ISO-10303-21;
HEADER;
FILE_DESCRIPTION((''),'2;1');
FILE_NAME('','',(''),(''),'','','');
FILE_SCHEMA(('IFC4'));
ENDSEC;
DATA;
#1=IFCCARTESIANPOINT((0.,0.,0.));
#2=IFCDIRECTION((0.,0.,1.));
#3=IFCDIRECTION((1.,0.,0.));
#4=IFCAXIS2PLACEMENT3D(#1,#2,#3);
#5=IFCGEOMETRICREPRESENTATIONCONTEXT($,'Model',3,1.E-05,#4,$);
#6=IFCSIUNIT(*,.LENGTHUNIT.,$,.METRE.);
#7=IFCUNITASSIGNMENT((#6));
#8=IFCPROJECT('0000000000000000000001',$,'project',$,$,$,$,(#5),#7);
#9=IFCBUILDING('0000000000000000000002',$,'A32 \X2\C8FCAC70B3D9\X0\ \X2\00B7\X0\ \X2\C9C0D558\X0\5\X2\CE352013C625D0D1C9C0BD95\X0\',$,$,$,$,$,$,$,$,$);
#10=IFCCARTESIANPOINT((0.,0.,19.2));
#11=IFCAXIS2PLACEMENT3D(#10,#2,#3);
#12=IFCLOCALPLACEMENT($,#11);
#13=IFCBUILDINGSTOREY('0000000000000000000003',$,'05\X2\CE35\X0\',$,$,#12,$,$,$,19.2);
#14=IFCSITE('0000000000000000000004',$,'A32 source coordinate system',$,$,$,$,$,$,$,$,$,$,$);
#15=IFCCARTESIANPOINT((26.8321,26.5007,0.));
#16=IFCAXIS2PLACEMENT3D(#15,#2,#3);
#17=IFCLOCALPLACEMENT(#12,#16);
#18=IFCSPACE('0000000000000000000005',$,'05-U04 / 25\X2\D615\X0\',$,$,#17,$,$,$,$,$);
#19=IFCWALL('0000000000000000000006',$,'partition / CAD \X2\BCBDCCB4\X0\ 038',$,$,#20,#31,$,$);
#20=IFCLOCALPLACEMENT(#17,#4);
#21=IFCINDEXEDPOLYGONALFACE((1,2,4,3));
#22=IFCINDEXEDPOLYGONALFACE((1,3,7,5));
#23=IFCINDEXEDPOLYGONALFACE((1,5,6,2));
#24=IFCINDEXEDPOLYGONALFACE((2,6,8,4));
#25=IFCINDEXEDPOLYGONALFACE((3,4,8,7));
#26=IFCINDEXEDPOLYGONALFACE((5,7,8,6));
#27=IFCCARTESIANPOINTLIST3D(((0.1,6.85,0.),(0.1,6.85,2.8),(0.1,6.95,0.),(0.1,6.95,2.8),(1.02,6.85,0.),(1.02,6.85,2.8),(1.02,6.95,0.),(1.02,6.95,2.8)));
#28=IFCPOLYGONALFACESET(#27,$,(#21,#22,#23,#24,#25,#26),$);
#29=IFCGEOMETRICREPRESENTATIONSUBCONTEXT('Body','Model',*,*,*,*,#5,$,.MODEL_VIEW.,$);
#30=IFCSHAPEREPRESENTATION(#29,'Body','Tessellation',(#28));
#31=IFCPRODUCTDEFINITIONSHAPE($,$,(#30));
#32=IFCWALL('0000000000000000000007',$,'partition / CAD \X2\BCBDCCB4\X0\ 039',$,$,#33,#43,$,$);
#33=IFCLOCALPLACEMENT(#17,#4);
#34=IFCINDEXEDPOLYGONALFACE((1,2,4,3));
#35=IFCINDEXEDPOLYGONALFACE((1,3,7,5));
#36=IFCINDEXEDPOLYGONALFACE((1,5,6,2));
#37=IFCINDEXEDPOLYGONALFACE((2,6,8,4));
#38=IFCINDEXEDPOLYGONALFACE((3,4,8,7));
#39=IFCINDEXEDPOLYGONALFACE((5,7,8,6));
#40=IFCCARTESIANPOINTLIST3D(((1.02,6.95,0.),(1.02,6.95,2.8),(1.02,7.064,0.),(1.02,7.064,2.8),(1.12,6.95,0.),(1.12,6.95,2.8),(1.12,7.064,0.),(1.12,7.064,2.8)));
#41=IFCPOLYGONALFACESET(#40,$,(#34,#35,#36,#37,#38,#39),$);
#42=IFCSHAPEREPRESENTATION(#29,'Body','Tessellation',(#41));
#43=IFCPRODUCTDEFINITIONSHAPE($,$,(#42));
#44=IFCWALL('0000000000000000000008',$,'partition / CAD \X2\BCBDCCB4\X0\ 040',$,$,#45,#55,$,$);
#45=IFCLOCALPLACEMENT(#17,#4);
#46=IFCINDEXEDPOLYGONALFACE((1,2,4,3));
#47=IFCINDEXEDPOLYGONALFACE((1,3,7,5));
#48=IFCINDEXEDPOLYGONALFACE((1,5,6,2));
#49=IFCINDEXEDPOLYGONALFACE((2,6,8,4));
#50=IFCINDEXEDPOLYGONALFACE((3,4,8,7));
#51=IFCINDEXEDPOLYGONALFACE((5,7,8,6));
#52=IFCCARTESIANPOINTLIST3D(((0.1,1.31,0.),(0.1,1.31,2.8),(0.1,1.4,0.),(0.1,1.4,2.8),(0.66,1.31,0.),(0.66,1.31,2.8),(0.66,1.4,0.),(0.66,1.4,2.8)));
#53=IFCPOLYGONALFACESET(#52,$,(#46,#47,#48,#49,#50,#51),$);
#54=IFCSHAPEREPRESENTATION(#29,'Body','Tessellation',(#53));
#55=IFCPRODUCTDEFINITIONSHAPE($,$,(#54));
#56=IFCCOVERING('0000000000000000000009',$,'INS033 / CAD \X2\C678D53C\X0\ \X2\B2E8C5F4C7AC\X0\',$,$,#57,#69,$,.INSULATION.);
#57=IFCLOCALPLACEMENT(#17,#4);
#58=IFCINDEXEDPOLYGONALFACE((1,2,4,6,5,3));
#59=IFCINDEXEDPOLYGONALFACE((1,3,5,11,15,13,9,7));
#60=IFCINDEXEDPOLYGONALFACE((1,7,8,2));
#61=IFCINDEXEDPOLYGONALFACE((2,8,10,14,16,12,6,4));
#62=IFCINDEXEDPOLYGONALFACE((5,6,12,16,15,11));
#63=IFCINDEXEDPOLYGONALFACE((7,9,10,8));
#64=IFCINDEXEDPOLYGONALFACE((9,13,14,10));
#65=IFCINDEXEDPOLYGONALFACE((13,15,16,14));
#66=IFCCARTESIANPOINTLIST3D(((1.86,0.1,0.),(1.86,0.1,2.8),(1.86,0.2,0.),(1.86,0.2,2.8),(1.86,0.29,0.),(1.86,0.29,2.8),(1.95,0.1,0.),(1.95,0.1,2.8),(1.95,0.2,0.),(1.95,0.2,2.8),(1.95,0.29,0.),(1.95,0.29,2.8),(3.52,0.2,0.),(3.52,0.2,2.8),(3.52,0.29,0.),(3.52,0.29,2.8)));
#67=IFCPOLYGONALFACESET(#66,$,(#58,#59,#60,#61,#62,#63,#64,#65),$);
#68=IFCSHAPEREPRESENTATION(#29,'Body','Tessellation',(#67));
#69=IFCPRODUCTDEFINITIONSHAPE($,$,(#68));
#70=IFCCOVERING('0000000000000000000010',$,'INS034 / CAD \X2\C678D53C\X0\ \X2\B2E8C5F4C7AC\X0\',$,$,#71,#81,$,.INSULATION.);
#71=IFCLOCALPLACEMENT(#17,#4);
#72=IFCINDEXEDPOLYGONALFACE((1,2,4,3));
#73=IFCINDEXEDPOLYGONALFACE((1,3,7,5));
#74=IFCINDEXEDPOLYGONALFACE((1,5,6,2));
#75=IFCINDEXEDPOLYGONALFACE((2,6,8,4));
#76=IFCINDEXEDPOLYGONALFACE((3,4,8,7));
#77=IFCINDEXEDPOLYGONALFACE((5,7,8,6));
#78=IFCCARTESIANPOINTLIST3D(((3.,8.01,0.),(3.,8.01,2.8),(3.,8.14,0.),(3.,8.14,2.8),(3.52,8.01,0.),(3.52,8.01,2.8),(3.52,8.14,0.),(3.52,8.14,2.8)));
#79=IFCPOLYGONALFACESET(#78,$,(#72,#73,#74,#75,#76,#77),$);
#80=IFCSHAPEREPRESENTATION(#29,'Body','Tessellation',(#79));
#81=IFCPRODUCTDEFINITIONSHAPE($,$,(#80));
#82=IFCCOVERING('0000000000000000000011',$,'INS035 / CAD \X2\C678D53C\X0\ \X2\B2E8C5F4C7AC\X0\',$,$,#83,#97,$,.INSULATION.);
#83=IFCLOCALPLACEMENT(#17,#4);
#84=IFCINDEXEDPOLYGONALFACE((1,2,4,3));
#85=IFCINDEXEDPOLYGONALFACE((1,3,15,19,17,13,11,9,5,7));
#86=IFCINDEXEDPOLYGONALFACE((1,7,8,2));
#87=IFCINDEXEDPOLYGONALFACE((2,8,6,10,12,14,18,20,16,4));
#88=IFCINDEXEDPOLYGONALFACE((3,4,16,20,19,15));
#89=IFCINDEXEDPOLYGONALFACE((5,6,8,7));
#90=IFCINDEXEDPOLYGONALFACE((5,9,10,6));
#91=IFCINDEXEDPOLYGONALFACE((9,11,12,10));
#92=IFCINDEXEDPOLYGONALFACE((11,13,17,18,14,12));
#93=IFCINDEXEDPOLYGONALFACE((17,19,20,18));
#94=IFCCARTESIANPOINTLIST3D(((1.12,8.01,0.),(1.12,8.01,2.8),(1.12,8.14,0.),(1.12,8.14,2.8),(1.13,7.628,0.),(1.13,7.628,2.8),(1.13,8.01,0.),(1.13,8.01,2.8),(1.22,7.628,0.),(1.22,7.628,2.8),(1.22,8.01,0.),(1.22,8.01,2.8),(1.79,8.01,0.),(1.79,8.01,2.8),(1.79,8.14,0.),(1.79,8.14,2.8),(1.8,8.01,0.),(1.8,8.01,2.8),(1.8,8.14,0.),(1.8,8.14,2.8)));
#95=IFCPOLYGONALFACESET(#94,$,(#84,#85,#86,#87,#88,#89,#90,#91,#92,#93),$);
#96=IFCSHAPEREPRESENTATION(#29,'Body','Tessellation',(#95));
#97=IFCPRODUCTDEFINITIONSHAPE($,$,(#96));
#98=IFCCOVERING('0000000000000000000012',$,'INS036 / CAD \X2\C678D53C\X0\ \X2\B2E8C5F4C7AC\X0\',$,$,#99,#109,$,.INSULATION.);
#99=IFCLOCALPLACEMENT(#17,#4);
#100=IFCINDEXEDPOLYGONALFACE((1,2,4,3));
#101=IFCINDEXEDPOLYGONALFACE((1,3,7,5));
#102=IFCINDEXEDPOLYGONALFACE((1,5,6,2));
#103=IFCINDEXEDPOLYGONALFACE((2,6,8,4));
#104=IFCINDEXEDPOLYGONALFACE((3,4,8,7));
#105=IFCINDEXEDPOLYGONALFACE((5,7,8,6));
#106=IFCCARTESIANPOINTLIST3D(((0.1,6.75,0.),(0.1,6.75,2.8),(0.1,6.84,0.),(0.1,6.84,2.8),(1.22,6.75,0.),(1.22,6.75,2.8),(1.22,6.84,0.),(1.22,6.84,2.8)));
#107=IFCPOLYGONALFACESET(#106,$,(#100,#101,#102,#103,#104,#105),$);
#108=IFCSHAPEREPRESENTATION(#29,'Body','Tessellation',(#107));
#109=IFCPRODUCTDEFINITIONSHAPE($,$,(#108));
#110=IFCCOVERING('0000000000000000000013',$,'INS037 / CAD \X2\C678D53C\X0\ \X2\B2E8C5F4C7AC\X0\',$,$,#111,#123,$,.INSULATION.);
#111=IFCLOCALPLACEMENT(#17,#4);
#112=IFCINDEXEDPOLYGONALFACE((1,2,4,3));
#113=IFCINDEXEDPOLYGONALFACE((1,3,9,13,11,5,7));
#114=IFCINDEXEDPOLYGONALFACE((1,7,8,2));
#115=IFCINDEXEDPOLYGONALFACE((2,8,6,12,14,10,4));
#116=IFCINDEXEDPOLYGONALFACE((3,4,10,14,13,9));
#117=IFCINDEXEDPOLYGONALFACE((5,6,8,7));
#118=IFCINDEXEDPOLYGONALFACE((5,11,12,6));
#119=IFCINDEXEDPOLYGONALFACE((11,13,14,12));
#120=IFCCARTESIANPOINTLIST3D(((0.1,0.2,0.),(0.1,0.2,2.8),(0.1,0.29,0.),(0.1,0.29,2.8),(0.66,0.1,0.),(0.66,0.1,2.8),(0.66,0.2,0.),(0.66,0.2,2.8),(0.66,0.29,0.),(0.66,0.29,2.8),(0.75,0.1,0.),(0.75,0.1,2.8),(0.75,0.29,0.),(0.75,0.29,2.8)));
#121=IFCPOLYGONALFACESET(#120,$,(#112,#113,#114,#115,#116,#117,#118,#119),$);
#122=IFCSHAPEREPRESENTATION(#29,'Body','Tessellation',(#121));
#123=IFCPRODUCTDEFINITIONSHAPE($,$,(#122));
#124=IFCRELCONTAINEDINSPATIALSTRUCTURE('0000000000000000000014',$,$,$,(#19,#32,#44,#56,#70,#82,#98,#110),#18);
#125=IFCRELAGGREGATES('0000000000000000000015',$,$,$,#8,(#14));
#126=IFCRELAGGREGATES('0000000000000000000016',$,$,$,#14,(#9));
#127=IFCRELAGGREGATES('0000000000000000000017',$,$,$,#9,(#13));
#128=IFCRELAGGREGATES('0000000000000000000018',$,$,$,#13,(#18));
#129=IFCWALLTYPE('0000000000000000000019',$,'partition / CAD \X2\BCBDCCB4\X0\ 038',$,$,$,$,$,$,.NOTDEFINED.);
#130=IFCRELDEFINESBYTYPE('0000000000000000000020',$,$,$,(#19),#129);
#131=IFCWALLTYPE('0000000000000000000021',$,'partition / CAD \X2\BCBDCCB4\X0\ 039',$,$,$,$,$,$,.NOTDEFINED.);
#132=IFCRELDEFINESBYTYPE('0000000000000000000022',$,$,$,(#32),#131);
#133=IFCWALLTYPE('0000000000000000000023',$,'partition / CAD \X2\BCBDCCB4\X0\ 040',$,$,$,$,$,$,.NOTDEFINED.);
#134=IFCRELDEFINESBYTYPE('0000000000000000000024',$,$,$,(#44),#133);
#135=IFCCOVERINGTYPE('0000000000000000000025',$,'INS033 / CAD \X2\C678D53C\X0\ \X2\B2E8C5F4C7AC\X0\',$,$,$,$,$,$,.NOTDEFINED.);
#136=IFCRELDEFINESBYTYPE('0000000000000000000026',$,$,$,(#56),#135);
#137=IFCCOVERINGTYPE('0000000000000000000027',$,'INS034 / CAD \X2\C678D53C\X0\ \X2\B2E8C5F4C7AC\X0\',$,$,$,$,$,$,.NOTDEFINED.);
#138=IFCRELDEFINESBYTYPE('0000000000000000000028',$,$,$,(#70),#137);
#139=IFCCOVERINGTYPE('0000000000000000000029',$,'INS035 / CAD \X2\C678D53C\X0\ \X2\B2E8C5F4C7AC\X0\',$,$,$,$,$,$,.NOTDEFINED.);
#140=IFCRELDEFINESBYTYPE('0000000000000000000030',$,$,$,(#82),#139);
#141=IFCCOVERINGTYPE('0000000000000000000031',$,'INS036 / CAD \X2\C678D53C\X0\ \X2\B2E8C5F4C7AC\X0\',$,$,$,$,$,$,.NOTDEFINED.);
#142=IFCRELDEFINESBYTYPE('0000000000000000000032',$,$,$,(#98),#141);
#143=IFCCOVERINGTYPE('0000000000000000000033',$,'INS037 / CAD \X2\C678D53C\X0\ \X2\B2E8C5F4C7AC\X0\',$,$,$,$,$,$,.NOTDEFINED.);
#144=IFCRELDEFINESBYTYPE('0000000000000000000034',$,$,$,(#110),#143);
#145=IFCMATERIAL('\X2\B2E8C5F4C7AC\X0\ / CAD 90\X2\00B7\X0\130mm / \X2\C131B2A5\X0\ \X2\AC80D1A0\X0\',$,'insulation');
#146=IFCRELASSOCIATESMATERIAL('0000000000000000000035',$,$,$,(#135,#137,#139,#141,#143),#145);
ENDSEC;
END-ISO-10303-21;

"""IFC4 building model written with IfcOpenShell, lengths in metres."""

from ifc_helpers import new_model, si_unit, frame, origin, origin_with_axes, place, context, subcontext, project, spatial, polyline, outline, extrude, source, transform, mapped, material, type_object, type_shapes, element, save


model = new_model("IFC4")

# Units and contexts
model_context = context("Model", 3, precision=1e-05, world=origin_with_axes())
body_context = subcontext(model_context, "Body", "Model", "MODEL_VIEW")
ifc_project = project(units=[si_unit("LENGTHUNIT", "METRE")], contexts=[model_context])

# Site, building, storey, space
storey_placement = place(None, frame((0.0, 0.0, 19.2), z_axis=(0.0, 0.0, 1.0), x_axis=(1.0, 0.0, 0.0)))
space_placement = place(storey_placement, frame((26.8321, 26.5007, 0.0), z_axis=(0.0, 0.0, 1.0), x_axis=(1.0, 0.0, 0.0)))
site = spatial("IfcSite", under=ifc_project, Name="A32 source coordinate system")
building = spatial("IfcBuilding", under=site, Name="A32 주거동 · 지하5층–옥탑지붕")
storey = spatial("IfcBuildingStorey", under=building, at=storey_placement, Name="05층", Elevation=19.2)
space = spatial("IfcSpace", under=storey, at=space_placement, Name="05-U04 / 25형")

# Walls
wall_type_1 = type_object("IfcWallType", Name="partition / CAD 벽체 038", PredefinedType="NOTDEFINED")
shared_shape_1 = source(origin(), body_context, "Body", "SweptSolid", [
    extrude(outline(polyline([(0.1, 6.95), (1.02, 6.95), (1.02, 6.85), (0.1, 6.85), (0.1, 6.95)])), origin(), (0.0, 0.0, 1.0), 2.8),
])
type_shapes(wall_type_1, [shared_shape_1])
wall_1_placement = place(space_placement, origin_with_axes())
element("IfcWall", 1, at=wall_1_placement, inside=space, type_object=wall_type_1, Name="partition / CAD 벽체 038", context=body_context, shape_type="MappedRepresentation", body=[
    mapped(shared_shape_1, transform((0.0, 0.0, 0.0), scale=1.0)),
])
wall_type_2 = type_object("IfcWallType", Name="partition / CAD 벽체 039", PredefinedType="NOTDEFINED")
shared_shape_2 = source(origin(), body_context, "Body", "SweptSolid", [
    extrude(outline(polyline([(1.02, 6.95), (1.02, 7.064), (1.12, 7.064), (1.12, 6.95), (1.02, 6.95)])), origin(), (0.0, 0.0, 1.0), 2.8),
])
type_shapes(wall_type_2, [shared_shape_2])
wall_2_placement = place(space_placement, origin_with_axes())
element("IfcWall", 2, at=wall_2_placement, inside=space, type_object=wall_type_2, Name="partition / CAD 벽체 039", context=body_context, shape_type="MappedRepresentation", body=[
    mapped(shared_shape_2, transform((0.0, 0.0, 0.0), scale=1.0)),
])
wall_type_3 = type_object("IfcWallType", Name="partition / CAD 벽체 040", PredefinedType="NOTDEFINED")
shared_shape_3 = source(origin(), body_context, "Body", "SweptSolid", [
    extrude(outline(polyline([(0.1, 1.4), (0.66, 1.4), (0.66, 1.31), (0.1, 1.31), (0.1, 1.4)])), origin(), (0.0, 0.0, 1.0), 2.8),
])
type_shapes(wall_type_3, [shared_shape_3])
wall_3_placement = place(space_placement, origin_with_axes())
element("IfcWall", 3, at=wall_3_placement, inside=space, type_object=wall_type_3, Name="partition / CAD 벽체 040", context=body_context, shape_type="MappedRepresentation", body=[
    mapped(shared_shape_3, transform((0.0, 0.0, 0.0), scale=1.0)),
])

# Coverings
ifc_material = material(Name="단열재 / CAD 90·130mm / 성능 검토", Category="insulation")
covering_type_1 = type_object("IfcCoveringType", Name="INS033 / CAD 외피 단열재", PredefinedType="NOTDEFINED", material=ifc_material)
shared_shape_4 = source(origin(), body_context, "Body", "SweptSolid", [
    extrude(outline(polyline([(1.95, 0.29), (3.52, 0.29), (3.52, 0.2), (1.95, 0.2), (1.95, 0.1), (1.86, 0.1), (1.86, 0.2), (1.86, 0.29), (1.95, 0.29)])), origin(), (0.0, 0.0, 1.0), 2.8),
])
type_shapes(covering_type_1, [shared_shape_4])
covering_1_placement = place(space_placement, origin_with_axes())
element("IfcCovering", 4, at=covering_1_placement, inside=space, type_object=covering_type_1, Name="INS033 / CAD 외피 단열재", PredefinedType="INSULATION", context=body_context, shape_type="MappedRepresentation", body=[
    mapped(shared_shape_4, transform((0.0, 0.0, 0.0), scale=1.0)),
])
covering_type_2 = type_object("IfcCoveringType", Name="INS034 / CAD 외피 단열재", PredefinedType="NOTDEFINED", material=ifc_material)
shared_shape_5 = source(origin(), body_context, "Body", "SweptSolid", [
    extrude(outline(polyline([(3.52, 8.01), (3.0, 8.01), (3.0, 8.14), (3.52, 8.14), (3.52, 8.01)])), origin(), (0.0, 0.0, 1.0), 2.8),
])
type_shapes(covering_type_2, [shared_shape_5])
covering_2_placement = place(space_placement, origin_with_axes())
element("IfcCovering", 5, at=covering_2_placement, inside=space, type_object=covering_type_2, Name="INS034 / CAD 외피 단열재", PredefinedType="INSULATION", context=body_context, shape_type="MappedRepresentation", body=[
    mapped(shared_shape_5, transform((0.0, 0.0, 0.0), scale=1.0)),
])
covering_type_3 = type_object("IfcCoveringType", Name="INS035 / CAD 외피 단열재", PredefinedType="NOTDEFINED", material=ifc_material)
shared_shape_6 = source(origin(), body_context, "Body", "SweptSolid", [
    extrude(outline(polyline([(1.8, 8.01), (1.79, 8.01), (1.22, 8.01), (1.22, 7.628), (1.13, 7.628), (1.13, 8.01), (1.12, 8.01), (1.12, 8.14), (1.79, 8.14), (1.8, 8.14), (1.8, 8.01)])), origin(), (0.0, 0.0, 1.0), 2.8),
])
type_shapes(covering_type_3, [shared_shape_6])
covering_3_placement = place(space_placement, origin_with_axes())
element("IfcCovering", 6, at=covering_3_placement, inside=space, type_object=covering_type_3, Name="INS035 / CAD 외피 단열재", PredefinedType="INSULATION", context=body_context, shape_type="MappedRepresentation", body=[
    mapped(shared_shape_6, transform((0.0, 0.0, 0.0), scale=1.0)),
])
covering_type_4 = type_object("IfcCoveringType", Name="INS036 / CAD 외피 단열재", PredefinedType="NOTDEFINED", material=ifc_material)
shared_shape_7 = source(origin(), body_context, "Body", "SweptSolid", [
    extrude(outline(polyline([(1.22, 6.84), (1.22, 6.75), (0.1, 6.75), (0.1, 6.84), (1.22, 6.84)])), origin(), (0.0, 0.0, 1.0), 2.8),
])
type_shapes(covering_type_4, [shared_shape_7])
covering_4_placement = place(space_placement, origin_with_axes())
element("IfcCovering", 7, at=covering_4_placement, inside=space, type_object=covering_type_4, Name="INS036 / CAD 외피 단열재", PredefinedType="INSULATION", context=body_context, shape_type="MappedRepresentation", body=[
    mapped(shared_shape_7, transform((0.0, 0.0, 0.0), scale=1.0)),
])
covering_type_5 = type_object("IfcCoveringType", Name="INS037 / CAD 외피 단열재", PredefinedType="NOTDEFINED", material=ifc_material)
shared_shape_8 = source(origin(), body_context, "Body", "SweptSolid", [
    extrude(outline(polyline([(0.1, 0.2), (0.1, 0.29), (0.66, 0.29), (0.75, 0.29), (0.75, 0.1), (0.66, 0.1), (0.66, 0.2), (0.1, 0.2)])), origin(), (0.0, 0.0, 1.0), 2.8),
])
type_shapes(covering_type_5, [shared_shape_8])
covering_5_placement = place(space_placement, origin_with_axes())
element("IfcCovering", 8, at=covering_5_placement, inside=space, type_object=covering_type_5, Name="INS037 / CAD 외피 단열재", PredefinedType="INSULATION", context=body_context, shape_type="MappedRepresentation", body=[
    mapped(shared_shape_8, transform((0.0, 0.0, 0.0), scale=1.0)),
])

save(model, "model.ifc")
